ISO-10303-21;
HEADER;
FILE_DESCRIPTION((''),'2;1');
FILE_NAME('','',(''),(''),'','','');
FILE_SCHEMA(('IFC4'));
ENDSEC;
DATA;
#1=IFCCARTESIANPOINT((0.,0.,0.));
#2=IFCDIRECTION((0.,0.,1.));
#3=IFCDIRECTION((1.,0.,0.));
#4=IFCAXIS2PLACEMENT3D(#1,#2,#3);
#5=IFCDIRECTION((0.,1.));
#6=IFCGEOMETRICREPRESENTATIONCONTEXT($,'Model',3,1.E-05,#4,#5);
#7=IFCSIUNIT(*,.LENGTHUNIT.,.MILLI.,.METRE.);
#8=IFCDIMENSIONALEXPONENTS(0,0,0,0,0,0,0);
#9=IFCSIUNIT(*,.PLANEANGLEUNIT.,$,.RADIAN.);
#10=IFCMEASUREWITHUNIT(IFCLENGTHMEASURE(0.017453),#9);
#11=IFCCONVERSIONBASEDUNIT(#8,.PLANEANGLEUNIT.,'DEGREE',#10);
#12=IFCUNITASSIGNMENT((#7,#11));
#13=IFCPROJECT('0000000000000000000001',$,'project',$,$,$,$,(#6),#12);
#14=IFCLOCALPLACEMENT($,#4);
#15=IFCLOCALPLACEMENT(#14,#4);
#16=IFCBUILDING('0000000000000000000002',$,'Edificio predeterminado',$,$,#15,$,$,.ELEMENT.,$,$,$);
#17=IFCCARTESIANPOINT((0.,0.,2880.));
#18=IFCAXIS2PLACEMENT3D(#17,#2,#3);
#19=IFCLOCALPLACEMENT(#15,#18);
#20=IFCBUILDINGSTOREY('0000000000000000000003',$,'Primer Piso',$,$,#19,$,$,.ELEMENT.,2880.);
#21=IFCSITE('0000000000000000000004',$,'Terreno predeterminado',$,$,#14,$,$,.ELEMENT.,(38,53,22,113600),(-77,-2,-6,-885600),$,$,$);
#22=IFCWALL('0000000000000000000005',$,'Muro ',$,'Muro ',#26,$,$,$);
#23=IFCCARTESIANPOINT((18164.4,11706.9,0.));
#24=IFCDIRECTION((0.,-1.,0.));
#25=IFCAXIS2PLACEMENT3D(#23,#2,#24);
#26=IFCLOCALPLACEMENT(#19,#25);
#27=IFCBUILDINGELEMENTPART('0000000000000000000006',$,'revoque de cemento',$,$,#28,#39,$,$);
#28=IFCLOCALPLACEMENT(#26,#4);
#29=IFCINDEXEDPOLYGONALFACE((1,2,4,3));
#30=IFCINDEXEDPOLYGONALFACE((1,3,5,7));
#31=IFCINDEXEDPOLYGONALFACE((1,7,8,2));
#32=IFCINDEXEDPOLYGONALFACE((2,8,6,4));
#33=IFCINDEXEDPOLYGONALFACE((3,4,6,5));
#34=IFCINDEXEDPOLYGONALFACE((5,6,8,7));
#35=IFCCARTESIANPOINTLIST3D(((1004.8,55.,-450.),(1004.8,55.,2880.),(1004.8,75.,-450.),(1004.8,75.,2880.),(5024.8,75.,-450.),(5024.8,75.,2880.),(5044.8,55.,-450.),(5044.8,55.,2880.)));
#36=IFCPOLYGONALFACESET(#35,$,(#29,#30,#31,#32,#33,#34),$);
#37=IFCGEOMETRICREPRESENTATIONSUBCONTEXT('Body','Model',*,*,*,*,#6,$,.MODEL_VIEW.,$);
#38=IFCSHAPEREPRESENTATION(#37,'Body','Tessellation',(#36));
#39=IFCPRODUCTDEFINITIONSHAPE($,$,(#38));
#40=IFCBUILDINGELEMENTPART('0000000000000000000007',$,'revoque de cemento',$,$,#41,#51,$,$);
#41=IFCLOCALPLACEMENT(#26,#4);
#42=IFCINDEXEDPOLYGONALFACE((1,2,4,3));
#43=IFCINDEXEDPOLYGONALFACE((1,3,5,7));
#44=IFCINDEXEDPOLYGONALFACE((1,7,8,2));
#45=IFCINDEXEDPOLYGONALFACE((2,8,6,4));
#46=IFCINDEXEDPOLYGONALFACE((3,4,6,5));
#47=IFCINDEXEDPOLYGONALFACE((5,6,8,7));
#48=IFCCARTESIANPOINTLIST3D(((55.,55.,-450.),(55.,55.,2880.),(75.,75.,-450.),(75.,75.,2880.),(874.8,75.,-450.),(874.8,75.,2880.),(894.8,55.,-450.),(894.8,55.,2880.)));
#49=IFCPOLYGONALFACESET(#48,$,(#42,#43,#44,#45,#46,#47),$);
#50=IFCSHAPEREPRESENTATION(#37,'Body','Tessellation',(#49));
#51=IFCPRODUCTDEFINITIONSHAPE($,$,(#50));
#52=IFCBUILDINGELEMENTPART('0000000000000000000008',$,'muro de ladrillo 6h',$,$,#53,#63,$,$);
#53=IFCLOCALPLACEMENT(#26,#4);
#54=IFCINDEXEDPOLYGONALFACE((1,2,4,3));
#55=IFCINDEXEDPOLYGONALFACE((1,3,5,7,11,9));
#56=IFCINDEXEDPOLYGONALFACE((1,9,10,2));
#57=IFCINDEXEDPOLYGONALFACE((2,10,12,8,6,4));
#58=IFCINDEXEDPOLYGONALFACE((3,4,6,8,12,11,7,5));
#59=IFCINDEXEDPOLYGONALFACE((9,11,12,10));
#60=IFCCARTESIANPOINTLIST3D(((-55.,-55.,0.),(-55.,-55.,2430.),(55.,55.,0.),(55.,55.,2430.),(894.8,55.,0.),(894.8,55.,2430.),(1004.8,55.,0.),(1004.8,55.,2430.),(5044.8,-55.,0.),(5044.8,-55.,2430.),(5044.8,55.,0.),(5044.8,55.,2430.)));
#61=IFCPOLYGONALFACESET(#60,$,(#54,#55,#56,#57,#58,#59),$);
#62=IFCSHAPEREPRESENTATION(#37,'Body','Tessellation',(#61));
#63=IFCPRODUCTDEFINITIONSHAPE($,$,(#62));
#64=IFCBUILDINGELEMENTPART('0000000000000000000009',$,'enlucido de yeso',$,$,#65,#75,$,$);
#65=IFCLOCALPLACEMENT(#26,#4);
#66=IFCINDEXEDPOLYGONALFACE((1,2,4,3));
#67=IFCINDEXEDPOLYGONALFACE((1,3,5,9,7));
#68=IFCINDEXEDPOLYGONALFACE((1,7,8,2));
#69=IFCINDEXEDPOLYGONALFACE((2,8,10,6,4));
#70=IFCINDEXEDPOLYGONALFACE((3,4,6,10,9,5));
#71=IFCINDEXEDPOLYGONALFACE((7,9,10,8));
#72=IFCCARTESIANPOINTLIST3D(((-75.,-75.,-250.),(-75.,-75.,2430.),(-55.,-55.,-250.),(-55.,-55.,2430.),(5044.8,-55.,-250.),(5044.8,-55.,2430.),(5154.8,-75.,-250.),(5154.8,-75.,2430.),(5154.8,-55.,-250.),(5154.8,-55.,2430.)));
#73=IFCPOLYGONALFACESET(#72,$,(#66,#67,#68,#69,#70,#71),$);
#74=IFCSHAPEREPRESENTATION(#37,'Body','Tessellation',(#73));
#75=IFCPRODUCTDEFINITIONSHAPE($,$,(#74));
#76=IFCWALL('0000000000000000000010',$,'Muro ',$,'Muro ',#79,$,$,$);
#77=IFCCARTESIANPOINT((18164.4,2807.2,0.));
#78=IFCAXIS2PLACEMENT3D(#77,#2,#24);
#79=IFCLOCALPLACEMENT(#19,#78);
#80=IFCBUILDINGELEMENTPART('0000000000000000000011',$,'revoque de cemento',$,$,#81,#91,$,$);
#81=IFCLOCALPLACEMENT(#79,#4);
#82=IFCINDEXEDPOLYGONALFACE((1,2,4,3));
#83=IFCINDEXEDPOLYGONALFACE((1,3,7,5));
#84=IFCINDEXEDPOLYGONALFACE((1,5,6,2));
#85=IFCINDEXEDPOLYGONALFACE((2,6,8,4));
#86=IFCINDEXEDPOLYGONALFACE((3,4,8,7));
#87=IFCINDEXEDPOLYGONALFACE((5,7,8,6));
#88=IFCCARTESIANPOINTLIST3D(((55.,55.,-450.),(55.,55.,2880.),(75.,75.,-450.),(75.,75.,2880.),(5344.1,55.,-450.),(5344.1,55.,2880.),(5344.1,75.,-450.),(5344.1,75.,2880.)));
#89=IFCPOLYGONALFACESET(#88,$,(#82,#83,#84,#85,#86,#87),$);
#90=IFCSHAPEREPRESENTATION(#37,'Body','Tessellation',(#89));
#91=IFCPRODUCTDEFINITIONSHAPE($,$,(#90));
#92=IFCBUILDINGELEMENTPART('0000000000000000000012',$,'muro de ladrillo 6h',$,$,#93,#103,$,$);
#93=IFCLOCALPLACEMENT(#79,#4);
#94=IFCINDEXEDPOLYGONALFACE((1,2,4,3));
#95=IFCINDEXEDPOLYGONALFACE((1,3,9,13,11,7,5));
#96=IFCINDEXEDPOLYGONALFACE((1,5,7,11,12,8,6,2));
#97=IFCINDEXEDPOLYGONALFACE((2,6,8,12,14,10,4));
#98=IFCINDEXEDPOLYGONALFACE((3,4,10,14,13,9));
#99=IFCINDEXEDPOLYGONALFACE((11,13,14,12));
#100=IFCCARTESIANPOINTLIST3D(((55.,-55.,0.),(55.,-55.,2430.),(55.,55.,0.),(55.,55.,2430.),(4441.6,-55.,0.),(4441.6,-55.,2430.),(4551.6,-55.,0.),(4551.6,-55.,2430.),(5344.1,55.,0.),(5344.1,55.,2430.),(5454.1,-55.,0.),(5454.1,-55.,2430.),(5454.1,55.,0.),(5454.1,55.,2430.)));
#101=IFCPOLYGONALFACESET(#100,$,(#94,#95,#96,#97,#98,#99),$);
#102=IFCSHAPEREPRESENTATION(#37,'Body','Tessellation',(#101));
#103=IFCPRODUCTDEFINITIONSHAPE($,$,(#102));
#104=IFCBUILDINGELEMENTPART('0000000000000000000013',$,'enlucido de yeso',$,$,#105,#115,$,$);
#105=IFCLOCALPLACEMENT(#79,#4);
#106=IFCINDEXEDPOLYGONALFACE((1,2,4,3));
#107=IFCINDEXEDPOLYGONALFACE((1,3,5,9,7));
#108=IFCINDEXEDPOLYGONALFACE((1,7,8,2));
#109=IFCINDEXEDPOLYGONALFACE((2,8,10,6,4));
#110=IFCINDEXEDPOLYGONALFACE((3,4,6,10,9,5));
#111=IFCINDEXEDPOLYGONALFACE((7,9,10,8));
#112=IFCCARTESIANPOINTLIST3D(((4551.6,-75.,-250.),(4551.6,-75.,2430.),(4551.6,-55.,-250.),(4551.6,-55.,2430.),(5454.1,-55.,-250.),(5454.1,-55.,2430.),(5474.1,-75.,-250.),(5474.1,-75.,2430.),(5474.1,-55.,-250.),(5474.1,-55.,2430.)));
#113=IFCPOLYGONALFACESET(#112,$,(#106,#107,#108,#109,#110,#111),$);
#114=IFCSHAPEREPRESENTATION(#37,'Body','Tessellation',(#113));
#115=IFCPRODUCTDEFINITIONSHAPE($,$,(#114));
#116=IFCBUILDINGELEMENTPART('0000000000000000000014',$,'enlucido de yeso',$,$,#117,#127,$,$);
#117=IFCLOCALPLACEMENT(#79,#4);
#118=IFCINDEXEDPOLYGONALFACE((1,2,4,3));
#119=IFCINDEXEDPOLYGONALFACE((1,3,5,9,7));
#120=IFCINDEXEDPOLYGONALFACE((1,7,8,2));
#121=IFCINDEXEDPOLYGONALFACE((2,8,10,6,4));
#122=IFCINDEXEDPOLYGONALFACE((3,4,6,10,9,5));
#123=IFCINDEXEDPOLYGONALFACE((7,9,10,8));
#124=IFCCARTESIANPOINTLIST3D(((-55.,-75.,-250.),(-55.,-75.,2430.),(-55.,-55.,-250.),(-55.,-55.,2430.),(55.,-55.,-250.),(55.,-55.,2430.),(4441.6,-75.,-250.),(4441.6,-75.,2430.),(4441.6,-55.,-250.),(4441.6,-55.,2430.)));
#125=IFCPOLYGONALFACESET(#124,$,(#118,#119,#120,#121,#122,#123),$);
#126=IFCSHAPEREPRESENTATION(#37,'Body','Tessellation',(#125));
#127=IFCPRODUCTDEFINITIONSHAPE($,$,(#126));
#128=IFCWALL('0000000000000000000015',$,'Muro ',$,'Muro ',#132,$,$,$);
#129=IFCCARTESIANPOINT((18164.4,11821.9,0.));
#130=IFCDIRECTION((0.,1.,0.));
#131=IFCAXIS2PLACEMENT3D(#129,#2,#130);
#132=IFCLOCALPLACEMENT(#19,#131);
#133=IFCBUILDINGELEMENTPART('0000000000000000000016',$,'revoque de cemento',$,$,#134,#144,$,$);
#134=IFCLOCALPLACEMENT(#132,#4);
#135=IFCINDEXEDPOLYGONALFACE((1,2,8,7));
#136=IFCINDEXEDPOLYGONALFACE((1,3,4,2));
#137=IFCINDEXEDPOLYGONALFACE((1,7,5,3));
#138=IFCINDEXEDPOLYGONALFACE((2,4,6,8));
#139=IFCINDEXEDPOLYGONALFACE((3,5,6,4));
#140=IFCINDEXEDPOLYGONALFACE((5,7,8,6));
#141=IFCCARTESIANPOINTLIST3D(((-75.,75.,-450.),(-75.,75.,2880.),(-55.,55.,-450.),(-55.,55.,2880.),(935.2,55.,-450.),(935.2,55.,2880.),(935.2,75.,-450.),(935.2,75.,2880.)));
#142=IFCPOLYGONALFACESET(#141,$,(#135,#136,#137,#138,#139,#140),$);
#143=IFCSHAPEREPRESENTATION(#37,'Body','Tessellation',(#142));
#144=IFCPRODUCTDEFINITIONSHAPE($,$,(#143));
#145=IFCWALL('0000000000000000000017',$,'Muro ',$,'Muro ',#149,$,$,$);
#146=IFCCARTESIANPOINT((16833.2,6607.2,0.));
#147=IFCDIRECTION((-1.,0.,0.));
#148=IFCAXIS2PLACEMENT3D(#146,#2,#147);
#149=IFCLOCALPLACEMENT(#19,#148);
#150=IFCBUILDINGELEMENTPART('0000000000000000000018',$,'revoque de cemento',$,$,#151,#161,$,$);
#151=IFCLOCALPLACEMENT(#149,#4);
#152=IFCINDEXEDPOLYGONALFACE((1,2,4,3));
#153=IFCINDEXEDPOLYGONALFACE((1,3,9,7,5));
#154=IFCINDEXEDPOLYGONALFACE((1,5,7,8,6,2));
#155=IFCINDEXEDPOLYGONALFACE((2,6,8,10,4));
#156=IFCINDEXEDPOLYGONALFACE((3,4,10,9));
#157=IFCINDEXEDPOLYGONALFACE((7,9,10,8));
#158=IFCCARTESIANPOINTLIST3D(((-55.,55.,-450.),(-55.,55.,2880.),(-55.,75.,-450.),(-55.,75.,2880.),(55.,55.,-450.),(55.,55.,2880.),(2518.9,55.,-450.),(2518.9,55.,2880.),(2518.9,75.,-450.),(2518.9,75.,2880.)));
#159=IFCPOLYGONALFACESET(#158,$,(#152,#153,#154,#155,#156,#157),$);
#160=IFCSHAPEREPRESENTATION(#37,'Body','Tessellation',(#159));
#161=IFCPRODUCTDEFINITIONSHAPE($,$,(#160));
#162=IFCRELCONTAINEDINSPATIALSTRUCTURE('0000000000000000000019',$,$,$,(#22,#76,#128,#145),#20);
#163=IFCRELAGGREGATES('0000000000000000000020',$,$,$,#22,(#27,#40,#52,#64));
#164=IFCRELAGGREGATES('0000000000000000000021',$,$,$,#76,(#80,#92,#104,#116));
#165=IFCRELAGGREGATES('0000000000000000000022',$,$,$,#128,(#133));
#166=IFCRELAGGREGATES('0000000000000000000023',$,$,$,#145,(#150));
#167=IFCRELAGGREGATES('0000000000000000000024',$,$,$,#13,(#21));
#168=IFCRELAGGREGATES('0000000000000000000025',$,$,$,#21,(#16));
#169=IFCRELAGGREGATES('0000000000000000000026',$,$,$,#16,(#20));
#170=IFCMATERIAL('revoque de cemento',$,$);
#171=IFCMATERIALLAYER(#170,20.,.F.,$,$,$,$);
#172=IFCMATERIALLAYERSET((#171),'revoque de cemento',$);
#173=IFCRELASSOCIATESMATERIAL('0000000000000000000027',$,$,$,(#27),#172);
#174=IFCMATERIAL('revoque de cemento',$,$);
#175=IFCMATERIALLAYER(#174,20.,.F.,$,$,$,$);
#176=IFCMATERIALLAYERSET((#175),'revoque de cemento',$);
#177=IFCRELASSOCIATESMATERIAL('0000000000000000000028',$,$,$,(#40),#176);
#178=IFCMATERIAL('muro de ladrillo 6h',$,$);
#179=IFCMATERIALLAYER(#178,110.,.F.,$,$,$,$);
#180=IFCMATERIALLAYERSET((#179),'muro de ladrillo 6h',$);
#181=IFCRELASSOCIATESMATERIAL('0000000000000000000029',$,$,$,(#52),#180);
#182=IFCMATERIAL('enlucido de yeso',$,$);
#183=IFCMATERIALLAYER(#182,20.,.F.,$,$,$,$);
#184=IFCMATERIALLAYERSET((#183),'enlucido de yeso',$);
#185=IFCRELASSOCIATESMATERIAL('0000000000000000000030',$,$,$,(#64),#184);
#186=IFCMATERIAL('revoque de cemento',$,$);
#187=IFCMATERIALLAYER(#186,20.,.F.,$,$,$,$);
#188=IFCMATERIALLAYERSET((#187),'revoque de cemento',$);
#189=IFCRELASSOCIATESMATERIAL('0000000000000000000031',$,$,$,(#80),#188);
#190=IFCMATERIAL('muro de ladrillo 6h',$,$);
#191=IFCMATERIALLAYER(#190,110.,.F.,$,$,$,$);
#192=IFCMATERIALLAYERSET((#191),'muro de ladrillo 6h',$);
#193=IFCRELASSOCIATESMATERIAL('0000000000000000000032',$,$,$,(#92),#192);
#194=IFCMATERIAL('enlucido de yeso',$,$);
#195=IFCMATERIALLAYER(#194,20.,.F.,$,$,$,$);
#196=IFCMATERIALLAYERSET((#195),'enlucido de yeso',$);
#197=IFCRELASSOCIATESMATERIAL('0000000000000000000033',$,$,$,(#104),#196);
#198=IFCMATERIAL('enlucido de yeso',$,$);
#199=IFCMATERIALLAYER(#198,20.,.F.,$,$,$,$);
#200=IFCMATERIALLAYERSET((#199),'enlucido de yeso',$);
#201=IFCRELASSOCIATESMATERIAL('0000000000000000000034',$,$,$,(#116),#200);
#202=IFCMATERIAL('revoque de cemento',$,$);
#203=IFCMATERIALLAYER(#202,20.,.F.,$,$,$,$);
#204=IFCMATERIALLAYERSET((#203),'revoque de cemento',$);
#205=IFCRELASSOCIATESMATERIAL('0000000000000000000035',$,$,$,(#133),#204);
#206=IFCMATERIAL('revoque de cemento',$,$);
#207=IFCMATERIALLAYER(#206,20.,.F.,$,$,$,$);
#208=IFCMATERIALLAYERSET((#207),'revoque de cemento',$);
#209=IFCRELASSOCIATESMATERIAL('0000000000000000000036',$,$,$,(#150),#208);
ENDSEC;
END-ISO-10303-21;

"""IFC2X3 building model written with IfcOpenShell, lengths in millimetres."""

from ifc_helpers import new_model, entity, si_unit, converted_unit, direction, frame, origin_with_axes, place, context, subcontext, project, spatial, polyline, outline, extrude, material, layer, layer_set, layer_usage, element, aggregate, save


model = new_model("IFC2X3")

# Units and contexts
model_context = context("Model", 3, precision=1e-05, world=origin_with_axes(), true_north=direction((0.0, 1.0)))
body_context = subcontext(model_context, "Body", "Model", "MODEL_VIEW")
ifc_project = project(units=[si_unit("LENGTHUNIT", "METRE", prefix="MILLI"), converted_unit("PLANEANGLEUNIT", "DEGREE", entity("IfcLengthMeasure", 0.017453), si_unit("PLANEANGLEUNIT", "RADIAN"), dimensions=[0, 0, 0, 0, 0, 0, 0])], contexts=[model_context])

# Site, building, storey
site_placement = place(None, origin_with_axes())
site = spatial("IfcSite", under=ifc_project, at=site_placement, Name="Terreno predeterminado", CompositionType="ELEMENT", RefLatitude=(38, 53, 22, 113600), RefLongitude=(-77, -2, -6, -885600))
building_placement = place(site_placement, origin_with_axes())
building = spatial("IfcBuilding", under=site, at=building_placement, Name="Edificio predeterminado", CompositionType="ELEMENT")
storey_placement = place(building_placement, frame((0.0, 0.0, 2880.0), z_axis=(0.0, 0.0, 1.0), x_axis=(1.0, 0.0, 0.0)))
storey = spatial("IfcBuildingStorey", under=building, at=storey_placement, Name="Primer Piso", CompositionType="ELEMENT", Elevation=2880.0)

# Walls, building element parts
wall_1_placement = place(storey_placement, frame((18164.4, 11706.9, 0.0), z_axis=(0.0, 0.0, 1.0), x_axis=(0.0, -1.0, 0.0)))
wall_1 = element("IfcWall", 1, at=wall_1_placement, inside=storey, Name="Muro ", ObjectType="Muro ")
ifc_material_1 = material(Name="revoque de cemento")
ifc_layer_1 = layer(ifc_material_1, 20.0, ventilated=False)
ifc_layer_set_1 = layer_set([ifc_layer_1], Name="revoque de cemento")
ifc_layer_usage_1 = layer_usage(ifc_layer_set_1, "AXIS2", "NEGATIVE", -75.0)
building_element_part_1_placement = place(wall_1_placement, origin_with_axes())
building_element_part_1 = element("IfcBuildingElementPart", 2, at=building_element_part_1_placement, material=ifc_layer_usage_1, Name="revoque de cemento", context=body_context, shape_type="SweptSolid", body=[
    extrude(outline(polyline([(5024.8, 75.0), (5044.8, 55.0), (1004.8, 55.0), (1004.8, 75.0), (5024.8, 75.0)])), frame((0.0, 0.0, -450.0), z_axis=(0.0, 0.0, 1.0), x_axis=(1.0, 0.0, 0.0)), (0.0, 0.0, 1.0), 3330.0),
])
ifc_material_2 = material(Name="revoque de cemento")
ifc_layer_2 = layer(ifc_material_2, 20.0, ventilated=False)
ifc_layer_set_2 = layer_set([ifc_layer_2], Name="revoque de cemento")
ifc_layer_usage_2 = layer_usage(ifc_layer_set_2, "AXIS2", "NEGATIVE", -75.0)
building_element_part_2_placement = place(wall_1_placement, origin_with_axes())
building_element_part_2 = element("IfcBuildingElementPart", 3, at=building_element_part_2_placement, material=ifc_layer_usage_2, Name="revoque de cemento", context=body_context, shape_type="SweptSolid", body=[
    extrude(outline(polyline([(874.8, 75.0), (894.8, 55.0), (55.0, 55.0), (75.0, 75.0), (874.8, 75.0)])), frame((0.0, 0.0, -450.0), z_axis=(0.0, 0.0, 1.0), x_axis=(1.0, 0.0, 0.0)), (0.0, 0.0, 1.0), 3330.0),
])
ifc_material_3 = material(Name="muro de ladrillo 6h")
ifc_layer_3 = layer(ifc_material_3, 110.0, ventilated=False)
ifc_layer_set_3 = layer_set([ifc_layer_3], Name="muro de ladrillo 6h")
ifc_layer_usage_3 = layer_usage(ifc_layer_set_3, "AXIS2", "NEGATIVE", -55.0)
building_element_part_3_placement = place(wall_1_placement, origin_with_axes())
building_element_part_3 = element("IfcBuildingElementPart", 4, at=building_element_part_3_placement, material=ifc_layer_usage_3, Name="muro de ladrillo 6h", context=body_context, shape_type="SweptSolid", body=[
    extrude(outline(polyline([(5044.8, 55.0), (5044.8, -55.0), (-55.0, -55.0), (55.0, 55.0), (894.8, 55.0), (1004.8, 55.0), (5044.8, 55.0)])), origin_with_axes(), (0.0, 0.0, 1.0), 2430.0),
])
ifc_material_4 = material(Name="enlucido de yeso")
ifc_layer_4 = layer(ifc_material_4, 20.0, ventilated=False)
ifc_layer_set_4 = layer_set([ifc_layer_4], Name="enlucido de yeso")
ifc_layer_usage_4 = layer_usage(ifc_layer_set_4, "AXIS2", "NEGATIVE", 55.0)
building_element_part_4_placement = place(wall_1_placement, origin_with_axes())
building_element_part_4 = element("IfcBuildingElementPart", 5, at=building_element_part_4_placement, material=ifc_layer_usage_4, Name="enlucido de yeso", context=body_context, shape_type="SweptSolid", body=[
    extrude(outline(polyline([(5154.8, -55.0), (5154.8, -75.0), (-75.0, -75.0), (-55.0, -55.0), (5044.8, -55.0), (5154.8, -55.0)])), frame((0.0, 0.0, -250.0), z_axis=(0.0, 0.0, 1.0), x_axis=(1.0, 0.0, 0.0)), (0.0, 0.0, 1.0), 2680.0),
])
aggregate(wall_1, [building_element_part_1, building_element_part_2, building_element_part_3, building_element_part_4])
wall_2_placement = place(storey_placement, frame((18164.4, 2807.2, 0.0), z_axis=(0.0, 0.0, 1.0), x_axis=(0.0, -1.0, 0.0)))
wall_2 = element("IfcWall", 6, at=wall_2_placement, inside=storey, Name="Muro ", ObjectType="Muro ")
ifc_material_5 = material(Name="revoque de cemento")
ifc_layer_5 = layer(ifc_material_5, 20.0, ventilated=False)
ifc_layer_set_5 = layer_set([ifc_layer_5], Name="revoque de cemento")
ifc_layer_usage_5 = layer_usage(ifc_layer_set_5, "AXIS2", "NEGATIVE", -75.0)
building_element_part_5_placement = place(wall_2_placement, origin_with_axes())
building_element_part_5 = element("IfcBuildingElementPart", 7, at=building_element_part_5_placement, material=ifc_layer_usage_5, Name="revoque de cemento", context=body_context, shape_type="SweptSolid", body=[
    extrude(outline(polyline([(5344.1, 75.0), (5344.1, 55.0), (55.0, 55.0), (75.0, 75.0), (5344.1, 75.0)])), frame((0.0, 0.0, -450.0), z_axis=(0.0, 0.0, 1.0), x_axis=(1.0, 0.0, 0.0)), (0.0, 0.0, 1.0), 3330.0),
])
ifc_material_6 = material(Name="muro de ladrillo 6h")
ifc_layer_6 = layer(ifc_material_6, 110.0, ventilated=False)
ifc_layer_set_6 = layer_set([ifc_layer_6], Name="muro de ladrillo 6h")
ifc_layer_usage_6 = layer_usage(ifc_layer_set_6, "AXIS2", "NEGATIVE", -55.0)
building_element_part_6_placement = place(wall_2_placement, origin_with_axes())
building_element_part_6 = element("IfcBuildingElementPart", 8, at=building_element_part_6_placement, material=ifc_layer_usage_6, Name="muro de ladrillo 6h", context=body_context, shape_type="SweptSolid", body=[
    extrude(outline(polyline([(5454.1, 55.0), (5454.1, -55.0), (4551.6, -55.0), (4441.6, -55.0), (55.0, -55.0), (55.0, 55.0), (5344.1, 55.0), (5454.1, 55.0)])), origin_with_axes(), (0.0, 0.0, 1.0), 2430.0),
])
ifc_material_7 = material(Name="enlucido de yeso")
ifc_layer_7 = layer(ifc_material_7, 20.0, ventilated=False)
ifc_layer_set_7 = layer_set([ifc_layer_7], Name="enlucido de yeso")
ifc_layer_usage_7 = layer_usage(ifc_layer_set_7, "AXIS2", "NEGATIVE", 55.0)
building_element_part_7_placement = place(wall_2_placement, origin_with_axes())
building_element_part_7 = element("IfcBuildingElementPart", 9, at=building_element_part_7_placement, material=ifc_layer_usage_7, Name="enlucido de yeso", context=body_context, shape_type="SweptSolid", body=[
    extrude(outline(polyline([(5474.1, -55.0), (5474.1, -75.0), (4551.6, -75.0), (4551.6, -55.0), (5454.1, -55.0), (5474.1, -55.0)])), frame((0.0, 0.0, -250.0), z_axis=(0.0, 0.0, 1.0), x_axis=(1.0, 0.0, 0.0)), (0.0, 0.0, 1.0), 2680.0),
])
ifc_material_8 = material(Name="enlucido de yeso")
ifc_layer_8 = layer(ifc_material_8, 20.0, ventilated=False)
ifc_layer_set_8 = layer_set([ifc_layer_8], Name="enlucido de yeso")
ifc_layer_usage_8 = layer_usage(ifc_layer_set_8, "AXIS2", "NEGATIVE", 55.0)
building_element_part_8_placement = place(wall_2_placement, origin_with_axes())
building_element_part_8 = element("IfcBuildingElementPart", 10, at=building_element_part_8_placement, material=ifc_layer_usage_8, Name="enlucido de yeso", context=body_context, shape_type="SweptSolid", body=[
    extrude(outline(polyline([(4441.6, -55.0), (4441.6, -75.0), (-55.0, -75.0), (-55.0, -55.0), (55.0, -55.0), (4441.6, -55.0)])), frame((0.0, 0.0, -250.0), z_axis=(0.0, 0.0, 1.0), x_axis=(1.0, 0.0, 0.0)), (0.0, 0.0, 1.0), 2680.0),
])
aggregate(wall_2, [building_element_part_5, building_element_part_6, building_element_part_7, building_element_part_8])

# Wall, building element part
wall_3_placement = place(storey_placement, frame((18164.4, 11821.9, 0.0), z_axis=(0.0, 0.0, 1.0), x_axis=(0.0, 1.0, 0.0)))
wall_3 = element("IfcWall", 11, at=wall_3_placement, inside=storey, Name="Muro ", ObjectType="Muro ")
ifc_material_9 = material(Name="revoque de cemento")
ifc_layer_9 = layer(ifc_material_9, 20.0, ventilated=False)
ifc_layer_set_9 = layer_set([ifc_layer_9], Name="revoque de cemento")
ifc_layer_usage_9 = layer_usage(ifc_layer_set_9, "AXIS2", "NEGATIVE", -75.0)
building_element_part_9_placement = place(wall_3_placement, origin_with_axes())
building_element_part_9 = element("IfcBuildingElementPart", 12, at=building_element_part_9_placement, material=ifc_layer_usage_9, Name="revoque de cemento", context=body_context, shape_type="SweptSolid", body=[
    extrude(outline(polyline([(935.2, 75.0), (935.2, 55.0), (-55.0, 55.0), (-75.0, 75.0), (935.2, 75.0)])), frame((0.0, 0.0, -450.0), z_axis=(0.0, 0.0, 1.0), x_axis=(1.0, 0.0, 0.0)), (0.0, 0.0, 1.0), 3330.0),
])
aggregate(wall_3, [building_element_part_9])

# Wall, building element part
wall_4_placement = place(storey_placement, frame((16833.2, 6607.2, 0.0), z_axis=(0.0, 0.0, 1.0), x_axis=(-1.0, 0.0, 0.0)))
wall_4 = element("IfcWall", 13, at=wall_4_placement, inside=storey, Name="Muro ", ObjectType="Muro ")
ifc_material_10 = material(Name="revoque de cemento")
ifc_layer_10 = layer(ifc_material_10, 20.0, ventilated=False)
ifc_layer_set_10 = layer_set([ifc_layer_10], Name="revoque de cemento")
ifc_layer_usage_10 = layer_usage(ifc_layer_set_10, "AXIS2", "NEGATIVE", -75.0)
building_element_part_10_placement = place(wall_4_placement, origin_with_axes())
building_element_part_10 = element("IfcBuildingElementPart", 14, at=building_element_part_10_placement, material=ifc_layer_usage_10, Name="revoque de cemento", context=body_context, shape_type="SweptSolid", body=[
    extrude(outline(polyline([(2518.9, 75.0), (2518.9, 55.0), (55.0, 55.0), (-55.0, 55.0), (-55.0, 75.0), (2518.9, 75.0)])), frame((0.0, 0.0, -450.0), z_axis=(0.0, 0.0, 1.0), x_axis=(1.0, 0.0, 0.0)), (0.0, 0.0, 1.0), 3330.0),
])
aggregate(wall_4, [building_element_part_10])

save(model, "model.ifc")
